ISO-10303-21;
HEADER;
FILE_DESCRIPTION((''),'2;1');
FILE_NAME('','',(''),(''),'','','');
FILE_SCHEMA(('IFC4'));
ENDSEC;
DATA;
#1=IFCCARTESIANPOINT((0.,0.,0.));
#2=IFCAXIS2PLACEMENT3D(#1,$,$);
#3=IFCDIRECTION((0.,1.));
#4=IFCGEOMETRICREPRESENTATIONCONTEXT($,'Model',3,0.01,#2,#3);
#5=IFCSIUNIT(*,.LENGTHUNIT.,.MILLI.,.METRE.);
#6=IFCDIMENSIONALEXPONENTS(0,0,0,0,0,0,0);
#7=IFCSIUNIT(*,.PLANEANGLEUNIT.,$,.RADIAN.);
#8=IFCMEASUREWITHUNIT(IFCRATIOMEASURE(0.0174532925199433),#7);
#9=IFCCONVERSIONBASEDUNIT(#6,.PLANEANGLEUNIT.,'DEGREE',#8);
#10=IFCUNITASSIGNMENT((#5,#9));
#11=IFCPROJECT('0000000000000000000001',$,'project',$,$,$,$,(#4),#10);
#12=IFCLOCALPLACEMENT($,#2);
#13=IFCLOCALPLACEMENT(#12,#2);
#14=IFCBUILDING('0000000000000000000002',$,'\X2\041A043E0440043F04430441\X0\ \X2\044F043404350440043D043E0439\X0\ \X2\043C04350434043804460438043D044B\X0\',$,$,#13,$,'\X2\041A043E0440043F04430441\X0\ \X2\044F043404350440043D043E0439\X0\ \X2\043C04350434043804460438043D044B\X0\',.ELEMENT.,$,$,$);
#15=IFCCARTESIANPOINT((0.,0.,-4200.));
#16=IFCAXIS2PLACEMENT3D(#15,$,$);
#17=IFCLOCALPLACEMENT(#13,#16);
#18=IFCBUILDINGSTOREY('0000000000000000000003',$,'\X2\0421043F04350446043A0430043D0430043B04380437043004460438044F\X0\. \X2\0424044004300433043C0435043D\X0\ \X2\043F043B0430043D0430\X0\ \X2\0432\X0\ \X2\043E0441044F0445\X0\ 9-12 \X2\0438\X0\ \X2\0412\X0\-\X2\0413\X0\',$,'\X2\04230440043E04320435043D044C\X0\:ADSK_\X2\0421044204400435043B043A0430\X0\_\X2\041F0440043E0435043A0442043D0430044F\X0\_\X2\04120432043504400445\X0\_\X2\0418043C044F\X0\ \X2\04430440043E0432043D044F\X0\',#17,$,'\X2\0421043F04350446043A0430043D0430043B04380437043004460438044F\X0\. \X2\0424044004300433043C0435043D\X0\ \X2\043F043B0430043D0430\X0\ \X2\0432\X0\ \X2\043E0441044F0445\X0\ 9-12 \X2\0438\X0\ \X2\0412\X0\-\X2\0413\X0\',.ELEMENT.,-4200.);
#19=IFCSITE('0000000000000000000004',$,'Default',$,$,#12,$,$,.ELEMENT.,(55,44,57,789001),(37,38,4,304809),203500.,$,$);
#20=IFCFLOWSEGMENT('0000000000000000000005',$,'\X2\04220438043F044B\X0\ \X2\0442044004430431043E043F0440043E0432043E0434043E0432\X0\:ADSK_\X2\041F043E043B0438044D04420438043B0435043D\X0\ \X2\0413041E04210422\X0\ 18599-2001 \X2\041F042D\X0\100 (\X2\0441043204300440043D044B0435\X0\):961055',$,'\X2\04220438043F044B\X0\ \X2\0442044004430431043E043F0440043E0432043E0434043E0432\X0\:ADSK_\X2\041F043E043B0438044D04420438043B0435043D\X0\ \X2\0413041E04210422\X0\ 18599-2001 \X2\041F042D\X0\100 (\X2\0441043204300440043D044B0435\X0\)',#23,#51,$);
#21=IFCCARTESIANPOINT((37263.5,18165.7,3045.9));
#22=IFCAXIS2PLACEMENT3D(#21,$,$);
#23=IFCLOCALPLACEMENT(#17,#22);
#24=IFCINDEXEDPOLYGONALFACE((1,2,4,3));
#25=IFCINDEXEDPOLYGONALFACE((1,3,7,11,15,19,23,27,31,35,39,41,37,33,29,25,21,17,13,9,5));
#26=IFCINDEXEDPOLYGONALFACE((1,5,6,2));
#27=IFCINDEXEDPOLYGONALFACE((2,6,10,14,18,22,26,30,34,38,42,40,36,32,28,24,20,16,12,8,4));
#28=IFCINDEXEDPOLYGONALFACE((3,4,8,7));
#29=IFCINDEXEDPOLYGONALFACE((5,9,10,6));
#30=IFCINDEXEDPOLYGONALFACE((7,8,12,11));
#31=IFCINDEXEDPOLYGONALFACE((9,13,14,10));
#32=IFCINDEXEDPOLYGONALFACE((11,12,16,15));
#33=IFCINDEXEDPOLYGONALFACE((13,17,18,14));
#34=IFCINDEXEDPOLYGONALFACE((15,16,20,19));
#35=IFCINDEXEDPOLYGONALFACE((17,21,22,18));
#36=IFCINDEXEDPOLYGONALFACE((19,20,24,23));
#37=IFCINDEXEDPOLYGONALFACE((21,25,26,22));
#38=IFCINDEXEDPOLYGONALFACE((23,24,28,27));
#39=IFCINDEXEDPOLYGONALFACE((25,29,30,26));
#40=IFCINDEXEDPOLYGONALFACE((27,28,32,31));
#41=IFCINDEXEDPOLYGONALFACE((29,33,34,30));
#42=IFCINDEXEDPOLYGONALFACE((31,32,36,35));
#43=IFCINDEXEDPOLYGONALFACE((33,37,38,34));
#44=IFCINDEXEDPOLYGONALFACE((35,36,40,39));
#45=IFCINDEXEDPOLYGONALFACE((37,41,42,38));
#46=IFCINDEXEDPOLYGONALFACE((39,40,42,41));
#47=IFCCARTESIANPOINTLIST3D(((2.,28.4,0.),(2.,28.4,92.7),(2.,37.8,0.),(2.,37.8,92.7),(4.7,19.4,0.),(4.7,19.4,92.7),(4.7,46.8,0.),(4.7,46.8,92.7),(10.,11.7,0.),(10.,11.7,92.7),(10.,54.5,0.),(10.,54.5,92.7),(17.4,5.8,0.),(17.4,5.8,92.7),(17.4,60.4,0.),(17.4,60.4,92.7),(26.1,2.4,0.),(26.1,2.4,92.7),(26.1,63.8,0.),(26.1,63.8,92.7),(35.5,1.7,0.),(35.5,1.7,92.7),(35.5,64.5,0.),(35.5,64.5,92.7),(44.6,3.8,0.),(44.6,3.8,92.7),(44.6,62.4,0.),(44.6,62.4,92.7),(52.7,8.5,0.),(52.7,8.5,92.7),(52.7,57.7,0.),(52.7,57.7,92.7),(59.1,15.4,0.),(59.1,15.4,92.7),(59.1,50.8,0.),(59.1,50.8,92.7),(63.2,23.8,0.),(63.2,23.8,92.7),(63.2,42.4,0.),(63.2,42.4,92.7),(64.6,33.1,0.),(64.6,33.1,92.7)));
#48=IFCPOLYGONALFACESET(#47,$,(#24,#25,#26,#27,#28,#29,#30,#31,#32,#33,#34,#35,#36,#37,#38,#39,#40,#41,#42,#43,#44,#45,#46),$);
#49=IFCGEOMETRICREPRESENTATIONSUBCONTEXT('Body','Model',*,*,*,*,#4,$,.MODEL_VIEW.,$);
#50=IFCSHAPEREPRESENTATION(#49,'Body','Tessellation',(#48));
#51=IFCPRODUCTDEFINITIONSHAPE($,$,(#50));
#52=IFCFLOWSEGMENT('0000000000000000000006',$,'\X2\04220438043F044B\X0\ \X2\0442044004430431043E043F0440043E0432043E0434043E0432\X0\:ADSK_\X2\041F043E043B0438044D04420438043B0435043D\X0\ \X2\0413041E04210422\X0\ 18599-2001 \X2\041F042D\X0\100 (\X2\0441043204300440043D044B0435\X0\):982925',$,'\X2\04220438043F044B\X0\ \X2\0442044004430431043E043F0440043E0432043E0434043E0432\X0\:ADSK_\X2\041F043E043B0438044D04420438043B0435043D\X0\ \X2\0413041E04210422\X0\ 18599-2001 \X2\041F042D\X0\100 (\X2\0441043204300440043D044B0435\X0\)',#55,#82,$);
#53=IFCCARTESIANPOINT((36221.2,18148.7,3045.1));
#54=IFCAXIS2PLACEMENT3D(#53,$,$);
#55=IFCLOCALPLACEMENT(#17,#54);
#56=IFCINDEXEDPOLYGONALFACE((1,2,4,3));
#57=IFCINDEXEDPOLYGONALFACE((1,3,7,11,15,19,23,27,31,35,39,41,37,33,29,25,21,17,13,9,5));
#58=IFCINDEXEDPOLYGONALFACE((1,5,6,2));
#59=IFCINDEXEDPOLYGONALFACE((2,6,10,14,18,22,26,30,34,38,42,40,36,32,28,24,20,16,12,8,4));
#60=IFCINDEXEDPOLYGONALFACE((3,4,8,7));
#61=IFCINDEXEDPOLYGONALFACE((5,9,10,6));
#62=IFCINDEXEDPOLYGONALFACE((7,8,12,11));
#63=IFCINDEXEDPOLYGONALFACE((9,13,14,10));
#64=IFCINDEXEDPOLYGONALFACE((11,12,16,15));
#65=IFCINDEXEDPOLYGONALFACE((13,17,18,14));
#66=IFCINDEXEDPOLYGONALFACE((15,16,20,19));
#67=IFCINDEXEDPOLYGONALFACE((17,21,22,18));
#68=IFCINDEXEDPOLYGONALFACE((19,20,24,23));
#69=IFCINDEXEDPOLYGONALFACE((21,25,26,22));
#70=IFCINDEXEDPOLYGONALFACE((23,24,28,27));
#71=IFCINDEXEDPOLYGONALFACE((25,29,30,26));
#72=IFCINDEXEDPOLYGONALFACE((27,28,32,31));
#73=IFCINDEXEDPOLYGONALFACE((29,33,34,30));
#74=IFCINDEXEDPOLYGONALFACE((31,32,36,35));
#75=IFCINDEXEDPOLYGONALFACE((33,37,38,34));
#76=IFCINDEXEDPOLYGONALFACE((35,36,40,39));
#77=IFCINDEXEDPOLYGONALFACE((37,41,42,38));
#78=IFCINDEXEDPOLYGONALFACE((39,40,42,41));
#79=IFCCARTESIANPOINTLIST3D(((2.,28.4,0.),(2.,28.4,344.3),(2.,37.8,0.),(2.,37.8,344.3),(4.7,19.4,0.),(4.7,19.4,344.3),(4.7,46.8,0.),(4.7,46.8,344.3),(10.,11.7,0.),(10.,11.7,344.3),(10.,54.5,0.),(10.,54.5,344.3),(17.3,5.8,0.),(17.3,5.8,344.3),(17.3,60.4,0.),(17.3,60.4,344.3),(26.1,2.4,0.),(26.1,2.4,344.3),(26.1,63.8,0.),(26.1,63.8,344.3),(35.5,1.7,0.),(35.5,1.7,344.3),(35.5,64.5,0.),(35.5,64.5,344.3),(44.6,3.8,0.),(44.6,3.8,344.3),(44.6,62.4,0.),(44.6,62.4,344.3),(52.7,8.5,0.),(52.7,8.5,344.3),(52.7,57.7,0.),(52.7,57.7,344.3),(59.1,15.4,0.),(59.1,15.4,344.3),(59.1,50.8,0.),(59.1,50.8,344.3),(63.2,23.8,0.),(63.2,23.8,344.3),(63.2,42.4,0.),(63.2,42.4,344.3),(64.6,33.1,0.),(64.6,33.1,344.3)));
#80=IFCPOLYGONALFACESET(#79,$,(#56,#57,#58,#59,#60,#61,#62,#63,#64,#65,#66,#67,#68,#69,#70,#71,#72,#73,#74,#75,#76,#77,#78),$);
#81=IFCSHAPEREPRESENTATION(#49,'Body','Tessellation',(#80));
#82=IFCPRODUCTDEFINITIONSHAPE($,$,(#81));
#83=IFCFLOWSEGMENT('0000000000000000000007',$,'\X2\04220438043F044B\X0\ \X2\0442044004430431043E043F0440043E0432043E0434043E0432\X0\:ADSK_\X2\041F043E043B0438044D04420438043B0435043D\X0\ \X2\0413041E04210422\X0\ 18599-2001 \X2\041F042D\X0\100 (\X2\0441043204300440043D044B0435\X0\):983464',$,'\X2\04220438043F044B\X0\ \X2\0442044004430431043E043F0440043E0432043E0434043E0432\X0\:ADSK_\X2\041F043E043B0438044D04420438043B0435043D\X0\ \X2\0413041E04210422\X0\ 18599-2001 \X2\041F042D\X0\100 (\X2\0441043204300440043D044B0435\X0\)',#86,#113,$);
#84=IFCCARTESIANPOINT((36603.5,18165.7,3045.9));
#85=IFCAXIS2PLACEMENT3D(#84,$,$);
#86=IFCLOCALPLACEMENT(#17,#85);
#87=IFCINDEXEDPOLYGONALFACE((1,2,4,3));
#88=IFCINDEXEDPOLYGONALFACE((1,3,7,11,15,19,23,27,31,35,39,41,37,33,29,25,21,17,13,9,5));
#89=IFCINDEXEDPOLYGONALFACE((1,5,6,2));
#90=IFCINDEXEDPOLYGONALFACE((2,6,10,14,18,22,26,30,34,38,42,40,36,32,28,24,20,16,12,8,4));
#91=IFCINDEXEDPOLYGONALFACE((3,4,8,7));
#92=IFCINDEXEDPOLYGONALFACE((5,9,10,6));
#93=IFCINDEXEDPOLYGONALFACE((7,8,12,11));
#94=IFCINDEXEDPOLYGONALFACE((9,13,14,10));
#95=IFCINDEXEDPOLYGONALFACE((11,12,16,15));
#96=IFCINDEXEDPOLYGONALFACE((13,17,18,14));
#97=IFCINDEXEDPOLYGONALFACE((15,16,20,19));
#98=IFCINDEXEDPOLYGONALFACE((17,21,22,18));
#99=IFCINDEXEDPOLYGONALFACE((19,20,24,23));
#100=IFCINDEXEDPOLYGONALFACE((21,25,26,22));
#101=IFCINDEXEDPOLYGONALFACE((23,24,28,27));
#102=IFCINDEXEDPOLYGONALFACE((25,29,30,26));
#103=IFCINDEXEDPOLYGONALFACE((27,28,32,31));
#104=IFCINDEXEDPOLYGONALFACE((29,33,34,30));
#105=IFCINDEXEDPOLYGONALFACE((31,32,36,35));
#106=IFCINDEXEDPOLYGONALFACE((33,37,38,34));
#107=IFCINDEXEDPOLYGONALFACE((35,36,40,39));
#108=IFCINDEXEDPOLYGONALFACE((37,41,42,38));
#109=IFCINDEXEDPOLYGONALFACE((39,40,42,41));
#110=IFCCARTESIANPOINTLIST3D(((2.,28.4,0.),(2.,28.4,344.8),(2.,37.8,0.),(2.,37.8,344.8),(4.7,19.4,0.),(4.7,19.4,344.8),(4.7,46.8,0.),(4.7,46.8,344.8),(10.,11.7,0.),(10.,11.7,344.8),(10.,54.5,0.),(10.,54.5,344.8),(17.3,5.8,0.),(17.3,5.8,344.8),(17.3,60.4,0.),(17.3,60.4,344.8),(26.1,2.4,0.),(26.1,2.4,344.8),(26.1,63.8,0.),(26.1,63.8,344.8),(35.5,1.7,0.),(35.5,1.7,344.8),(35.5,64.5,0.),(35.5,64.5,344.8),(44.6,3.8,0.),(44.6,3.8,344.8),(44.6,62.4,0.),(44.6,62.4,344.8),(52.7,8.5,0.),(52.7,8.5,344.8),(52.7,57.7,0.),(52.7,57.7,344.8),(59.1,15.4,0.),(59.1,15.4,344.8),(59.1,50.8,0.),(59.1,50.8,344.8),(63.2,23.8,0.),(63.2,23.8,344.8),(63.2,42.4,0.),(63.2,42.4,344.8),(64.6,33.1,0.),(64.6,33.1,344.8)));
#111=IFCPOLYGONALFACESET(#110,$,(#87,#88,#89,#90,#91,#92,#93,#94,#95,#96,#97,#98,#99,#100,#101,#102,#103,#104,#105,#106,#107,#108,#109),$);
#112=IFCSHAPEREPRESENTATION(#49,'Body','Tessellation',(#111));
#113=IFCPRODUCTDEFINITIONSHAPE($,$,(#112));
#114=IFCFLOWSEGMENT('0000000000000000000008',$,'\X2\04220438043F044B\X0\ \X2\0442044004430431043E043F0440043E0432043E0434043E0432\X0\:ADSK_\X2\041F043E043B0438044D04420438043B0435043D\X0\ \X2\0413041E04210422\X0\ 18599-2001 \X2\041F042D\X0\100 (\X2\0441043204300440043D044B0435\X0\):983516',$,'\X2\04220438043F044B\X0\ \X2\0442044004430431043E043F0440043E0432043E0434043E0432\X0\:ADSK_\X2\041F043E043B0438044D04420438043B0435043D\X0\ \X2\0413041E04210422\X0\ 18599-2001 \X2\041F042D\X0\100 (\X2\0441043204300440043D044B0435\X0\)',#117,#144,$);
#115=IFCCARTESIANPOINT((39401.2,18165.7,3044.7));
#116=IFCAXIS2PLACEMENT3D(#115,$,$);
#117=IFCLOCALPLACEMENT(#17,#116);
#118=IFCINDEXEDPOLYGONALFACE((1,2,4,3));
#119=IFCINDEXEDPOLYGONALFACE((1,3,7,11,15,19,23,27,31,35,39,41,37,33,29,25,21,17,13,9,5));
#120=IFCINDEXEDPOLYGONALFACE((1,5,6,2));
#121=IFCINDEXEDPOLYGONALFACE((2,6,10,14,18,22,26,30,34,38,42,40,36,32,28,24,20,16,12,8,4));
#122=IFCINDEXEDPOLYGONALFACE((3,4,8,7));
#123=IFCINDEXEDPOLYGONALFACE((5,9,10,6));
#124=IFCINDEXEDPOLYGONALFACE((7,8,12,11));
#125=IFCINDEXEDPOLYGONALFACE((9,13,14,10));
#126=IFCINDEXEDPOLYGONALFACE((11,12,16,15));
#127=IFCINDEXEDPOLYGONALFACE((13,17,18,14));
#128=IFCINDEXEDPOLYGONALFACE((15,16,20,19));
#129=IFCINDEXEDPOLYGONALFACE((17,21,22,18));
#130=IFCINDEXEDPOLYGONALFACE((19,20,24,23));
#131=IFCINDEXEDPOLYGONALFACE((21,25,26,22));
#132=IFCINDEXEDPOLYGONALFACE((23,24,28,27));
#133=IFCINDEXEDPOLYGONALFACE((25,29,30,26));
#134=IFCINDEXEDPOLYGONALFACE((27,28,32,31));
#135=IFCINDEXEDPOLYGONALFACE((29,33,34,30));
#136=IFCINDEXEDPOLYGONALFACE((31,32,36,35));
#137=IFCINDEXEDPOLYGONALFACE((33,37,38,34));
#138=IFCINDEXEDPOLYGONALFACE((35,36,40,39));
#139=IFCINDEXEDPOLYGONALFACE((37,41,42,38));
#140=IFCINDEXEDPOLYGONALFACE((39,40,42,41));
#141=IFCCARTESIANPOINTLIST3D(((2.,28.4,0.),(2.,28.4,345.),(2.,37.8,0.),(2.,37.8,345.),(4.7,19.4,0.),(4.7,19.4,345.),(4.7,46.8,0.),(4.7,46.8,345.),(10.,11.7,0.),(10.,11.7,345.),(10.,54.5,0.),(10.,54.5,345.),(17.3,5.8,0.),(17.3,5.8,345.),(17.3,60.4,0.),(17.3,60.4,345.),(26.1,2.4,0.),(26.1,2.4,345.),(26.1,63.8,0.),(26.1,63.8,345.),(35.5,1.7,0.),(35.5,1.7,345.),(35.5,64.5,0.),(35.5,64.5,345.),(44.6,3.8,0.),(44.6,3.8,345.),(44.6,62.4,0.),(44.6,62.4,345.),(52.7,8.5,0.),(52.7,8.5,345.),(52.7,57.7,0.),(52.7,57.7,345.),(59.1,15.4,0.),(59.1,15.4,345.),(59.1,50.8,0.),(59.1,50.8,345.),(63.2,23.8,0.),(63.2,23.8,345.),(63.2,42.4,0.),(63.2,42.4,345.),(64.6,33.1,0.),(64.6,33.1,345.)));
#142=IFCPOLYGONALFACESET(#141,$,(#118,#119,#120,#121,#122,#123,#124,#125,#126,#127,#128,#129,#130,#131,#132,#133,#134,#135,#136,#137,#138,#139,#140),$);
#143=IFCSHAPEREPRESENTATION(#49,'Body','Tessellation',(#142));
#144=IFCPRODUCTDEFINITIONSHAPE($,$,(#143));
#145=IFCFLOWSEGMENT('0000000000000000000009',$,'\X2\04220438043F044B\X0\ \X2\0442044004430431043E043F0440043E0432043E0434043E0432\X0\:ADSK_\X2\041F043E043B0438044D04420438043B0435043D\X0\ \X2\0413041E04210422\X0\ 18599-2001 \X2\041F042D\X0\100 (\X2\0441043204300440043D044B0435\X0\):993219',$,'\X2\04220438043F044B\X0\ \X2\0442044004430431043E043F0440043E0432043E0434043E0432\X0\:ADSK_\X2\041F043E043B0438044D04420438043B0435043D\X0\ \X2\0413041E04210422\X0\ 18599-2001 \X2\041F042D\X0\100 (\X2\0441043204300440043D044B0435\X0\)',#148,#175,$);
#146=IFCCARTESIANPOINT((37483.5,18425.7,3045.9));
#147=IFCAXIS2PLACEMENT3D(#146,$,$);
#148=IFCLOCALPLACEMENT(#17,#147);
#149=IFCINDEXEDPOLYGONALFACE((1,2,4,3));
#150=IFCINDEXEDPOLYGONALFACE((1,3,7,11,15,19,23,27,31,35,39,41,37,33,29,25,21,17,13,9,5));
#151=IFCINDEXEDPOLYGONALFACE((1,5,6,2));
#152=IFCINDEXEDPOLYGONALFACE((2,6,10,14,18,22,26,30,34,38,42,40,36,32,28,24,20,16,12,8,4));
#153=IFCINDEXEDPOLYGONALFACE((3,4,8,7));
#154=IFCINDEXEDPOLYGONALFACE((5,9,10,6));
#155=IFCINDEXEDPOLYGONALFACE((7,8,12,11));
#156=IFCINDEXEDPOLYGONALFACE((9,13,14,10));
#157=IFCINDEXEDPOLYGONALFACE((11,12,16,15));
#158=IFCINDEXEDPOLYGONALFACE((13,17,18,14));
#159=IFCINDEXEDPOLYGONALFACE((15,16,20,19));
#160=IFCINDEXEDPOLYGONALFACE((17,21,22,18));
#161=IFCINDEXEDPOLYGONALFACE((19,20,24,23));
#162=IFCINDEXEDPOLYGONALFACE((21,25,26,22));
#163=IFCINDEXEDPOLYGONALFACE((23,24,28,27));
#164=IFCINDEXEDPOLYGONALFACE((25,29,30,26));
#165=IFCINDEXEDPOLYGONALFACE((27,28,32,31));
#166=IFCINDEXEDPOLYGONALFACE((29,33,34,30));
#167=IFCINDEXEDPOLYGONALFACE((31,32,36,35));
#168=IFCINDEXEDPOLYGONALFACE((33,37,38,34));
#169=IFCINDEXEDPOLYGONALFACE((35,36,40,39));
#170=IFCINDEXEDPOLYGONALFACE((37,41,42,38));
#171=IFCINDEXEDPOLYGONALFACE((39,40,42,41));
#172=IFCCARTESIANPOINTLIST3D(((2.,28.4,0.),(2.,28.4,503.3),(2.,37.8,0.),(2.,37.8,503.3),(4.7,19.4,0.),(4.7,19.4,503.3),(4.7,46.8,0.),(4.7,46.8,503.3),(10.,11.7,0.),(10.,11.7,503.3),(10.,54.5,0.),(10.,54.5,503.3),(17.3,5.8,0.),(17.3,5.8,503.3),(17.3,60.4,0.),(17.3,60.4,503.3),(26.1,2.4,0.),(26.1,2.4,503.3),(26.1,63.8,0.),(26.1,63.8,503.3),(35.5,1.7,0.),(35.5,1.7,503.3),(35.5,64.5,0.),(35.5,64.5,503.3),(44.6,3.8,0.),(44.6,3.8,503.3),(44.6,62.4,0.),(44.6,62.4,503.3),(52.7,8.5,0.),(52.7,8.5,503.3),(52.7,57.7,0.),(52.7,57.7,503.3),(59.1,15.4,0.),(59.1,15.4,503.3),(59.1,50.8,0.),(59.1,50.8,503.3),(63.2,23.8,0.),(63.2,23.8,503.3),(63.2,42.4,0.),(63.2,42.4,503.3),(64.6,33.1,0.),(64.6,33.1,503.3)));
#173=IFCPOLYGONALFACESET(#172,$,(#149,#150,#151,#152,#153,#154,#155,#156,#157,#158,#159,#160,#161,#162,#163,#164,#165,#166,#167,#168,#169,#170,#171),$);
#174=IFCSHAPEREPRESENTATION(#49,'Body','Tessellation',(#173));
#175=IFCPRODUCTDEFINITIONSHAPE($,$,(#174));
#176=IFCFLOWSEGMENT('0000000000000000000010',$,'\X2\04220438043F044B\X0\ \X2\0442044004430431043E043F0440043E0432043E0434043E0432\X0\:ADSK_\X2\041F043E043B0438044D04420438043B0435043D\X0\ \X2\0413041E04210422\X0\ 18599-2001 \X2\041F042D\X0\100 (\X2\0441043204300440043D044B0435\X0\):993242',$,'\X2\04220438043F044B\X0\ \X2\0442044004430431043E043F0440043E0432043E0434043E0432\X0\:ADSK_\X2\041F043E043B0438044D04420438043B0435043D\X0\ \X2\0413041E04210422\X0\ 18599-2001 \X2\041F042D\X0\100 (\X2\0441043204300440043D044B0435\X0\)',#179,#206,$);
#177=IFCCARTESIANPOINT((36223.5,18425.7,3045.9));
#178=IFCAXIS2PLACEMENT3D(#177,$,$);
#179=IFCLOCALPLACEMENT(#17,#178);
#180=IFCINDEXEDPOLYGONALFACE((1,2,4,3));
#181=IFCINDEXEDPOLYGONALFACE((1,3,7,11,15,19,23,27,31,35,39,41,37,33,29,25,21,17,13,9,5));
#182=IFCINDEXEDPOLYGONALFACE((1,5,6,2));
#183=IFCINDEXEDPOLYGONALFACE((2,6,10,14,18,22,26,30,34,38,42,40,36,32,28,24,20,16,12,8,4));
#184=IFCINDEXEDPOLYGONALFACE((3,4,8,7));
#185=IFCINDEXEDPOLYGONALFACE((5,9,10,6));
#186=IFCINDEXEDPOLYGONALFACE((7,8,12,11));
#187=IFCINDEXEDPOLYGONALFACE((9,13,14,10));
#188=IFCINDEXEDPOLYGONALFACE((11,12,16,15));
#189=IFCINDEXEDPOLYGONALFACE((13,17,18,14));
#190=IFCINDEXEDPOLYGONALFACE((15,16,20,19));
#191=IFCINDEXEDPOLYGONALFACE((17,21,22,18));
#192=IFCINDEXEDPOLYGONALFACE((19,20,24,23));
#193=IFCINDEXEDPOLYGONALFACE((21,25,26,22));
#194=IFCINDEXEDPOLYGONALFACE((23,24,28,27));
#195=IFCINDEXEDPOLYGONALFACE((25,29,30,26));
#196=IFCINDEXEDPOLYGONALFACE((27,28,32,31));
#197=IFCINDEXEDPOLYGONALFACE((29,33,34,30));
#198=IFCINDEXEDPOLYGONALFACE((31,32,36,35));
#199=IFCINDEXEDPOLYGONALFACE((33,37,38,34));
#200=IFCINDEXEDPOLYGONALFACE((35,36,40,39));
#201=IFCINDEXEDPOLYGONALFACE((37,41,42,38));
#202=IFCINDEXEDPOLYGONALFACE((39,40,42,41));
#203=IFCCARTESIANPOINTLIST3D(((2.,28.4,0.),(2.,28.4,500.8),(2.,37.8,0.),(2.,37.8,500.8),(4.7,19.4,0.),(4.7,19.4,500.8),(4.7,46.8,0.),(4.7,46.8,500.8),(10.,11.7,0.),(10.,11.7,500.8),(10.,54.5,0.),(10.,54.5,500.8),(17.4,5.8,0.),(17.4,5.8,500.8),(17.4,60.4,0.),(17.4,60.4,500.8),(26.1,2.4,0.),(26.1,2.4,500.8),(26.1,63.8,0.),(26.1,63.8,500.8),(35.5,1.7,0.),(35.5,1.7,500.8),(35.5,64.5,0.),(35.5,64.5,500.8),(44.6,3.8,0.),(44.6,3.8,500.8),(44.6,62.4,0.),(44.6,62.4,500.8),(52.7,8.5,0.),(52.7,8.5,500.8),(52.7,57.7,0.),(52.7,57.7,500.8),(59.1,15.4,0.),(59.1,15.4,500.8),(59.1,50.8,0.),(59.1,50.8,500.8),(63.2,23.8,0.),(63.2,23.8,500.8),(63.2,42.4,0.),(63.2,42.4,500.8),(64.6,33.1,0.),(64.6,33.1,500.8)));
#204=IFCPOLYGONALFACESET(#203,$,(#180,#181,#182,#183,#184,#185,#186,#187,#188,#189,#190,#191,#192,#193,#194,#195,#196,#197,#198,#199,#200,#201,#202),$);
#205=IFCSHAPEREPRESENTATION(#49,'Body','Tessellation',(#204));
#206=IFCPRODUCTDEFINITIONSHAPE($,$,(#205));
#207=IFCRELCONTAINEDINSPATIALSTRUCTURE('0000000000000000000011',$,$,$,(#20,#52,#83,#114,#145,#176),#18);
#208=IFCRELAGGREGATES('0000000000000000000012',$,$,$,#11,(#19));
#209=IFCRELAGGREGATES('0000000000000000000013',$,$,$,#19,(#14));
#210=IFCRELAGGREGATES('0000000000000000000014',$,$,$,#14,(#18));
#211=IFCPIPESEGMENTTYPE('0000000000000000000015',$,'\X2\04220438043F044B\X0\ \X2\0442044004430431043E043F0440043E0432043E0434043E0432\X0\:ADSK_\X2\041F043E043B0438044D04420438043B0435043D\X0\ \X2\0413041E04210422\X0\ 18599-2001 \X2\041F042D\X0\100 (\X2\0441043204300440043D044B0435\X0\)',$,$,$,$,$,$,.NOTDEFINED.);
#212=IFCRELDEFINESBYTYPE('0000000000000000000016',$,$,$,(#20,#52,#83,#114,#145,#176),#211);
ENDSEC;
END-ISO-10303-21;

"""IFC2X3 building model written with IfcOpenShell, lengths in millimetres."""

from ifc_helpers import new_model, entity, si_unit, converted_unit, direction, frame, origin, origin_2d_with_axis, place, context, subcontext, project, spatial, circle, extrude, type_object, element, save


model = new_model("IFC2X3")

# Units and contexts
model_context = context("Model", 3, precision=0.01, world=origin(), true_north=direction((0.0, 1.0)))
body_context = subcontext(model_context, "Body", "Model", "MODEL_VIEW")
ifc_project = project(units=[si_unit("LENGTHUNIT", "METRE", prefix="MILLI"), converted_unit("PLANEANGLEUNIT", "DEGREE", entity("IfcRatioMeasure", 0.0174532925199433), si_unit("PLANEANGLEUNIT", "RADIAN"), dimensions=[0, 0, 0, 0, 0, 0, 0])], contexts=[model_context])

# Site, building, storey
site_placement = place(None, origin())
site = spatial("IfcSite", under=ifc_project, at=site_placement, Name="Default", CompositionType="ELEMENT", RefLatitude=(55, 44, 57, 789001), RefLongitude=(37, 38, 4, 304809), RefElevation=203500.0)
building_placement = place(site_placement, origin())
building = spatial("IfcBuilding", under=site, at=building_placement, Name="Корпус ядерной медицины", LongName="Корпус ядерной медицины", CompositionType="ELEMENT")
storey_placement = place(building_placement, frame((0.0, 0.0, -4200.0)))
storey = spatial("IfcBuildingStorey", under=building, at=storey_placement, Name="Спецканализация. Фрагмен плана в осях 9-12 и В-Г", ObjectType="Уровень:ADSK_Стрелка_Проектная_Вверх_Имя уровня", LongName="Спецканализация. Фрагмен плана в осях 9-12 и В-Г", CompositionType="ELEMENT", Elevation=-4200.0)

# Flow segments
pipe_segment_type = type_object("IfcPipeSegmentType", Name="Типы трубопроводов:ADSK_Полиэтилен ГОСТ 18599-2001 ПЭ100 (сварные)", PredefinedType="NOTDEFINED")
flow_segment_1_placement = place(storey_placement, frame((37263.5, 18165.7, 3045.9)))
element("IfcFlowSegment", 1, at=flow_segment_1_placement, inside=storey, type_object=pipe_segment_type, Name="Типы трубопроводов:ADSK_Полиэтилен ГОСТ 18599-2001 ПЭ100 (сварные):961055", ObjectType="Типы трубопроводов:ADSK_Полиэтилен ГОСТ 18599-2001 ПЭ100 (сварные)", context=body_context, shape_type="SweptSolid", body=[
    extrude(circle(Radius=31.5, at=origin_2d_with_axis()), frame((33.1, 33.1, 0.0)), (0.0, 0.0, 1.0), 92.7),
])
flow_segment_2_placement = place(storey_placement, frame((36221.2, 18148.7, 3045.1)))
element("IfcFlowSegment", 2, at=flow_segment_2_placement, inside=storey, type_object=pipe_segment_type, Name="Типы трубопроводов:ADSK_Полиэтилен ГОСТ 18599-2001 ПЭ100 (сварные):982925", ObjectType="Типы трубопроводов:ADSK_Полиэтилен ГОСТ 18599-2001 ПЭ100 (сварные)", context=body_context, shape_type="SweptSolid", body=[
    extrude(circle(Radius=31.5, at=origin_2d_with_axis()), frame((33.1, 33.1, 0.0)), (0.0, 0.0, 1.0), 344.3),
])
flow_segment_3_placement = place(storey_placement, frame((36603.5, 18165.7, 3045.9)))
element("IfcFlowSegment", 3, at=flow_segment_3_placement, inside=storey, type_object=pipe_segment_type, Name="Типы трубопроводов:ADSK_Полиэтилен ГОСТ 18599-2001 ПЭ100 (сварные):983464", ObjectType="Типы трубопроводов:ADSK_Полиэтилен ГОСТ 18599-2001 ПЭ100 (сварные)", context=body_context, shape_type="SweptSolid", body=[
    extrude(circle(Radius=31.5, at=origin_2d_with_axis()), frame((33.1, 33.1, 0.0)), (0.0, 0.0, 1.0), 344.8),
])
flow_segment_4_placement = place(storey_placement, frame((39401.2, 18165.7, 3044.7)))
element("IfcFlowSegment", 4, at=flow_segment_4_placement, inside=storey, type_object=pipe_segment_type, Name="Типы трубопроводов:ADSK_Полиэтилен ГОСТ 18599-2001 ПЭ100 (сварные):983516", ObjectType="Типы трубопроводов:ADSK_Полиэтилен ГОСТ 18599-2001 ПЭ100 (сварные)", context=body_context, shape_type="SweptSolid", body=[
    extrude(circle(Radius=31.5, at=origin_2d_with_axis()), frame((33.1, 33.1, 0.0)), (0.0, 0.0, 1.0), 345.0),
])
flow_segment_5_placement = place(storey_placement, frame((37483.5, 18425.7, 3045.9)))
element("IfcFlowSegment", 5, at=flow_segment_5_placement, inside=storey, type_object=pipe_segment_type, Name="Типы трубопроводов:ADSK_Полиэтилен ГОСТ 18599-2001 ПЭ100 (сварные):993219", ObjectType="Типы трубопроводов:ADSK_Полиэтилен ГОСТ 18599-2001 ПЭ100 (сварные)", context=body_context, shape_type="SweptSolid", body=[
    extrude(circle(Radius=31.5, at=origin_2d_with_axis()), frame((33.1, 33.1, 0.0)), (0.0, 0.0, 1.0), 503.3),
])
flow_segment_6_placement = place(storey_placement, frame((36223.5, 18425.7, 3045.9)))
element("IfcFlowSegment", 6, at=flow_segment_6_placement, inside=storey, type_object=pipe_segment_type, Name="Типы трубопроводов:ADSK_Полиэтилен ГОСТ 18599-2001 ПЭ100 (сварные):993242", ObjectType="Типы трубопроводов:ADSK_Полиэтилен ГОСТ 18599-2001 ПЭ100 (сварные)", context=body_context, shape_type="SweptSolid", body=[
    extrude(circle(Radius=31.5, at=origin_2d_with_axis()), frame((33.1, 33.1, 0.0)), (0.0, 0.0, 1.0), 500.8),
])

save(model, "model.ifc")
